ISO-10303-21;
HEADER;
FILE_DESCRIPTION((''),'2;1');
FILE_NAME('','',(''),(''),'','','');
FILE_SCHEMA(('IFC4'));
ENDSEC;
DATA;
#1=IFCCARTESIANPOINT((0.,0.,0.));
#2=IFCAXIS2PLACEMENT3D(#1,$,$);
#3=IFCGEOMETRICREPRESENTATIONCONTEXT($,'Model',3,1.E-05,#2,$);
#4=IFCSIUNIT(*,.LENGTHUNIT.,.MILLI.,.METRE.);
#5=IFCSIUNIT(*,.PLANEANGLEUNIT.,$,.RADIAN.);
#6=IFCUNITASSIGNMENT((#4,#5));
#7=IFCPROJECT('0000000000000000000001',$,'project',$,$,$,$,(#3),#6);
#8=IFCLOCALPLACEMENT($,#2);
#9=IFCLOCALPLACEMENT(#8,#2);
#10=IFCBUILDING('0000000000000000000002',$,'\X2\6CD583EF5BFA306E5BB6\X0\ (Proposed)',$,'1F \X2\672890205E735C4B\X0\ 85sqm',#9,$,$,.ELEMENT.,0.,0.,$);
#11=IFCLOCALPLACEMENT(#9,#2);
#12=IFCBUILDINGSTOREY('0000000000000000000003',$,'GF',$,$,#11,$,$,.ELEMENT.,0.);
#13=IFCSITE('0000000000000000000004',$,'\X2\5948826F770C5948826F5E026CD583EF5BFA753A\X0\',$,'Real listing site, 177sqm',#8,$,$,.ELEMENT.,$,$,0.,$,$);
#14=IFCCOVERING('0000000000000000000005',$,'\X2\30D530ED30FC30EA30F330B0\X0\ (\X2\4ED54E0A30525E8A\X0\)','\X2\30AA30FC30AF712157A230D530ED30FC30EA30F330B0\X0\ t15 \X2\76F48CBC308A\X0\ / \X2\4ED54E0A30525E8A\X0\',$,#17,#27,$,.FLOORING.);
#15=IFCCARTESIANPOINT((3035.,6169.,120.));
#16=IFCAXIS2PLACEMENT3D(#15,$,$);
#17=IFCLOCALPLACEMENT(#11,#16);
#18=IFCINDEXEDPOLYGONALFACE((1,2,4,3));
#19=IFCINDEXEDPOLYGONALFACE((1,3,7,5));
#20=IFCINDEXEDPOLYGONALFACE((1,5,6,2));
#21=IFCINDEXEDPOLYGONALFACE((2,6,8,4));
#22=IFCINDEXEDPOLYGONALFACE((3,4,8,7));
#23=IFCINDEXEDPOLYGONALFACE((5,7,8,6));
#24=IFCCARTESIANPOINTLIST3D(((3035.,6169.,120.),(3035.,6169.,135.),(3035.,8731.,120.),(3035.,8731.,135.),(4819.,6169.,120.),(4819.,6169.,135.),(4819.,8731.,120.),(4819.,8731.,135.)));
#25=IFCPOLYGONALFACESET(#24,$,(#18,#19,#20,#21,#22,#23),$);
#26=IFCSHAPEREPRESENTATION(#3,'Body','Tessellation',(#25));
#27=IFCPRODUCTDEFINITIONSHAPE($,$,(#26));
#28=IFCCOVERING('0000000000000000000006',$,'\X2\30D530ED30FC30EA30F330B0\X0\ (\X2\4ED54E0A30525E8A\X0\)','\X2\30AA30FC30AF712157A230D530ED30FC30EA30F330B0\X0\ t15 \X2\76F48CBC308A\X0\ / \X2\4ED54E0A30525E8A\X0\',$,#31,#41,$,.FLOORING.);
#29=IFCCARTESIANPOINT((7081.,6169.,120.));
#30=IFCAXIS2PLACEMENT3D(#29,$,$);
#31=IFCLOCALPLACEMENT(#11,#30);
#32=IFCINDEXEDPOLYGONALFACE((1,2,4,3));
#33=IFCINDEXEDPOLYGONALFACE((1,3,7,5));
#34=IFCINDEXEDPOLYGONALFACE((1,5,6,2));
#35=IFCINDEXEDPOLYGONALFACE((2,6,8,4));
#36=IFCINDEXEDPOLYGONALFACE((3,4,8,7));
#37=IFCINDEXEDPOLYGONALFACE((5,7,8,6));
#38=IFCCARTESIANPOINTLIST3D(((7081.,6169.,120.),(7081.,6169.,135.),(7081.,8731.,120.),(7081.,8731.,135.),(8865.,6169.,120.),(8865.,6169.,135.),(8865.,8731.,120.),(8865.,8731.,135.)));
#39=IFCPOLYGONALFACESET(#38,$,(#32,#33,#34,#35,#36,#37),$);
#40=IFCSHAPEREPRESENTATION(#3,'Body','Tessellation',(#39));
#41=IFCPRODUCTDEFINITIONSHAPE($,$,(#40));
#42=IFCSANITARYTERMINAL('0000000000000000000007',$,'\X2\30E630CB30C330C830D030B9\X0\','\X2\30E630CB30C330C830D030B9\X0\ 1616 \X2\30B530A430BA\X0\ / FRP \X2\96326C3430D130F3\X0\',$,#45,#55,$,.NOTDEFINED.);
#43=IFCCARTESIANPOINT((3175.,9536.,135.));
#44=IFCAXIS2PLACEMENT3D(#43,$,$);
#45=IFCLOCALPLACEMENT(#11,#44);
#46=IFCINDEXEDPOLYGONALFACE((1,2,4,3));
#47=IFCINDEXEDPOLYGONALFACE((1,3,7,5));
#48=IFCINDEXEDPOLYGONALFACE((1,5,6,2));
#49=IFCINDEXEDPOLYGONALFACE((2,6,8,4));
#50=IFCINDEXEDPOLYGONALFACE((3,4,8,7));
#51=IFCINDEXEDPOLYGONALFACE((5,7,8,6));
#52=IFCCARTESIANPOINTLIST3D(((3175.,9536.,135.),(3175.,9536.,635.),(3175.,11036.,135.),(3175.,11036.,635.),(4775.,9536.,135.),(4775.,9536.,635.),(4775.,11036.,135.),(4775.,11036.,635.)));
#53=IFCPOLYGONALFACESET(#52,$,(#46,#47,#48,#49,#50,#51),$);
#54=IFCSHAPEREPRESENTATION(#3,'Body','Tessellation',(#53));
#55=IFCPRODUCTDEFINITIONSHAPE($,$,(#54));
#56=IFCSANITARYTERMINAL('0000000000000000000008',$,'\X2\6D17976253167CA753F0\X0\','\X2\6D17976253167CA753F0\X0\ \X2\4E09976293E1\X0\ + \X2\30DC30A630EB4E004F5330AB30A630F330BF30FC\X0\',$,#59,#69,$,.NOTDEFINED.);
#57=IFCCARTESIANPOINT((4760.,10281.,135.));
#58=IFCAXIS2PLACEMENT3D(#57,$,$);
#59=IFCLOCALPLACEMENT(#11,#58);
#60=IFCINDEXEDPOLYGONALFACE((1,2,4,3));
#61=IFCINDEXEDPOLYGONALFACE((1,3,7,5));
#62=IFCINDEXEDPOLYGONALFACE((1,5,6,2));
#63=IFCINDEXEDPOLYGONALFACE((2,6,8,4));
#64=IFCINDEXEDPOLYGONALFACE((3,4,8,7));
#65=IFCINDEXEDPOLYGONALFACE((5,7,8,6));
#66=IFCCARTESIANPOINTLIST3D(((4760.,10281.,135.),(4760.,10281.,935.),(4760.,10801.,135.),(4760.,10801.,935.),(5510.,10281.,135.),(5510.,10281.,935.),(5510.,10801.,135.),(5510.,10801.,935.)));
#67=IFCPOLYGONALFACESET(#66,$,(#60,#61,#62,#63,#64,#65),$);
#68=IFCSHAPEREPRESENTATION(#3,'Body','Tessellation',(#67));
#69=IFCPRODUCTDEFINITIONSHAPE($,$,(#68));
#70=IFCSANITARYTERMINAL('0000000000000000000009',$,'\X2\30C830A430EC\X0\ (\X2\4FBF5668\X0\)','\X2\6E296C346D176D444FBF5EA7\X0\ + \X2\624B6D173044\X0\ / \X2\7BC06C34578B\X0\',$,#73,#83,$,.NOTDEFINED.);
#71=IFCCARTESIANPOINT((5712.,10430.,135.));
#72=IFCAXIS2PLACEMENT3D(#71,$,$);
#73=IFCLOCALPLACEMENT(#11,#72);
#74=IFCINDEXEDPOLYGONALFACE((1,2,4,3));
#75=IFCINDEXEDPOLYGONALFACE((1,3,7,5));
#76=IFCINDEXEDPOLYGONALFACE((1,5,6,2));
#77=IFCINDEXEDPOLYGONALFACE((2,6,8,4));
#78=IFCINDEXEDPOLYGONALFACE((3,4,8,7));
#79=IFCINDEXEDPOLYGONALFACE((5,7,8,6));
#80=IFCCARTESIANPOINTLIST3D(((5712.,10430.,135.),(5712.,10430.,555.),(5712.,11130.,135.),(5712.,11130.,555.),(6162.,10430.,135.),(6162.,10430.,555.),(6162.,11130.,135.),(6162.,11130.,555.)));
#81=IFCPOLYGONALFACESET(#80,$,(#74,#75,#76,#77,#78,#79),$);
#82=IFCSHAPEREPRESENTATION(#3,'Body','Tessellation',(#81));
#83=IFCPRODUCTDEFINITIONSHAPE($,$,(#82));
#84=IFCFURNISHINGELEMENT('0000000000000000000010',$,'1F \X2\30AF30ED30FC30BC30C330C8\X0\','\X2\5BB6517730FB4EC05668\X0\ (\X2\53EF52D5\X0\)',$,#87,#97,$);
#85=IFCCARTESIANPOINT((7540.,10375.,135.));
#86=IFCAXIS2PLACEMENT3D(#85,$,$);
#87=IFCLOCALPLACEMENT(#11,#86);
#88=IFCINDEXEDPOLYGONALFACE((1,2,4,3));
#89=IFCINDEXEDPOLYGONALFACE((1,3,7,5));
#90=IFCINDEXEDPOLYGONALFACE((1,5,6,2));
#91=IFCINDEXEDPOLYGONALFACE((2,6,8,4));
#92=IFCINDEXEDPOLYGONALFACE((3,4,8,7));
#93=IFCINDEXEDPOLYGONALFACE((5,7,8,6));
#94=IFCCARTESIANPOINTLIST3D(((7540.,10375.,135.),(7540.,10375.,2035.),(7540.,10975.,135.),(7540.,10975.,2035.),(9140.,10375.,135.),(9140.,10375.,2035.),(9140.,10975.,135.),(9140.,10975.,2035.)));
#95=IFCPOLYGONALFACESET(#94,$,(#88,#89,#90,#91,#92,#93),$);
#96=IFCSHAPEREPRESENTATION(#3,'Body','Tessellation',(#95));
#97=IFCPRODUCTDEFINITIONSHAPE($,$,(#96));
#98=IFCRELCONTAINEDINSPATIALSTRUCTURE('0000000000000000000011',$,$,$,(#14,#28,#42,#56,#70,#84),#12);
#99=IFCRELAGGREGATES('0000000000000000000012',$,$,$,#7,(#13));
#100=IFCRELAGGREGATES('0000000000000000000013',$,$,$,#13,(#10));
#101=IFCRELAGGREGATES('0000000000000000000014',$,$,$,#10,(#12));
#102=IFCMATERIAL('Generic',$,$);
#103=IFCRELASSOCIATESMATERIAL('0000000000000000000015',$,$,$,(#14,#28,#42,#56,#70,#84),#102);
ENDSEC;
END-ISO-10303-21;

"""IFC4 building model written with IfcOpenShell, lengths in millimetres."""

from ifc_helpers import new_model, si_unit, frame, frame_2d, origin, place, context, project, spatial, rectangle, extrude, material, element, save


model = new_model("IFC4")

# Units and contexts
model_context = context("Model", 3, precision=1e-05, world=origin())
ifc_project = project(units=[si_unit("LENGTHUNIT", "METRE", prefix="MILLI"), si_unit("PLANEANGLEUNIT", "RADIAN")], contexts=[model_context])

# Site, building, storey
site_placement = place(None, origin())
site = spatial("IfcSite", under=ifc_project, at=site_placement, Name="奈良県奈良市法華寺町", ObjectType="Real listing site, 177sqm", CompositionType="ELEMENT", RefElevation=0.0)
building_placement = place(site_placement, origin())
building = spatial("IfcBuilding", under=site, at=building_placement, Name="法華寺の家 (Proposed)", ObjectType="1F 木造平屋 85sqm", CompositionType="ELEMENT", ElevationOfRefHeight=0.0, ElevationOfTerrain=0.0)
storey_placement = place(building_placement, origin())
storey = spatial("IfcBuildingStorey", under=building, at=storey_placement, Name="GF", CompositionType="ELEMENT", Elevation=0.0)

# Coverings
ifc_material_1 = material(Name="Generic")
covering_1_placement = place(storey_placement, frame((3035.0, 6169.0, 120.0)))
element("IfcCovering", 1, at=covering_1_placement, inside=storey, material=ifc_material_1, Name="フローリング (仕上げ床)", Description="オーク無垢フローリング t15 直貼り / 仕上げ床", PredefinedType="FLOORING", context=model_context, shape_type="SweptSolid", body=[
    extrude(rectangle(XDim=1784.0, YDim=2562.0, at=frame_2d((892.0, 1281.0))), frame((3035.0, 6169.0, 120.0)), (0.0, 0.0, 1.0), 15.0),
])
covering_2_placement = place(storey_placement, frame((7081.0, 6169.0, 120.0)))
element("IfcCovering", 2, at=covering_2_placement, inside=storey, material=ifc_material_1, Name="フローリング (仕上げ床)", Description="オーク無垢フローリング t15 直貼り / 仕上げ床", PredefinedType="FLOORING", context=model_context, shape_type="SweptSolid", body=[
    extrude(rectangle(XDim=1784.0, YDim=2562.0, at=frame_2d((892.0, 1281.0))), frame((7081.0, 6169.0, 120.0)), (0.0, 0.0, 1.0), 15.0),
])

# Sanitary terminals
sanitary_terminal_1_placement = place(storey_placement, frame((3175.0, 9536.0, 135.0)))
element("IfcSanitaryTerminal", 3, at=sanitary_terminal_1_placement, inside=storey, material=ifc_material_1, Name="ユニットバス", Description="ユニットバス 1616 サイズ / FRP 防水パン", PredefinedType="NOTDEFINED", context=model_context, shape_type="SweptSolid", body=[
    extrude(rectangle(XDim=1600.0, YDim=1500.0, at=frame_2d((800.0, 750.0))), frame((3175.0, 9536.0, 135.0)), (0.0, 0.0, 1.0), 500.0),
])
sanitary_terminal_2_placement = place(storey_placement, frame((4760.0, 10281.0, 135.0)))
element("IfcSanitaryTerminal", 4, at=sanitary_terminal_2_placement, inside=storey, material=ifc_material_1, Name="洗面化粧台", Description="洗面化粧台 三面鏡 + ボウル一体カウンター", PredefinedType="NOTDEFINED", context=model_context, shape_type="SweptSolid", body=[
    extrude(rectangle(XDim=750.0, YDim=520.0, at=frame_2d((375.0, 260.0))), frame((4760.0, 10281.0, 135.0)), (0.0, 0.0, 1.0), 800.0),
])
sanitary_terminal_3_placement = place(storey_placement, frame((5712.0, 10430.0, 135.0)))
element("IfcSanitaryTerminal", 5, at=sanitary_terminal_3_placement, inside=storey, material=ifc_material_1, Name="トイレ (便器)", Description="温水洗浄便座 + 手洗い / 節水型", PredefinedType="NOTDEFINED", context=model_context, shape_type="SweptSolid", body=[
    extrude(rectangle(XDim=450.0, YDim=700.0, at=frame_2d((225.0, 350.0))), frame((5712.0, 10430.0, 135.0)), (0.0, 0.0, 1.0), 420.0),
])

# Furnishing element
furnishing_placement = place(storey_placement, frame((7540.0, 10375.0, 135.0)))
element("IfcFurnishingElement", 6, at=furnishing_placement, inside=storey, material=ifc_material_1, Name="1F クローゼット", Description="家具・什器 (可動)", context=model_context, shape_type="SweptSolid", body=[
    extrude(rectangle(XDim=1600.0, YDim=600.0, at=frame_2d((800.0, 300.0))), frame((7540.0, 10375.0, 135.0)), (0.0, 0.0, 1.0), 1900.0),
])

save(model, "model.ifc")
